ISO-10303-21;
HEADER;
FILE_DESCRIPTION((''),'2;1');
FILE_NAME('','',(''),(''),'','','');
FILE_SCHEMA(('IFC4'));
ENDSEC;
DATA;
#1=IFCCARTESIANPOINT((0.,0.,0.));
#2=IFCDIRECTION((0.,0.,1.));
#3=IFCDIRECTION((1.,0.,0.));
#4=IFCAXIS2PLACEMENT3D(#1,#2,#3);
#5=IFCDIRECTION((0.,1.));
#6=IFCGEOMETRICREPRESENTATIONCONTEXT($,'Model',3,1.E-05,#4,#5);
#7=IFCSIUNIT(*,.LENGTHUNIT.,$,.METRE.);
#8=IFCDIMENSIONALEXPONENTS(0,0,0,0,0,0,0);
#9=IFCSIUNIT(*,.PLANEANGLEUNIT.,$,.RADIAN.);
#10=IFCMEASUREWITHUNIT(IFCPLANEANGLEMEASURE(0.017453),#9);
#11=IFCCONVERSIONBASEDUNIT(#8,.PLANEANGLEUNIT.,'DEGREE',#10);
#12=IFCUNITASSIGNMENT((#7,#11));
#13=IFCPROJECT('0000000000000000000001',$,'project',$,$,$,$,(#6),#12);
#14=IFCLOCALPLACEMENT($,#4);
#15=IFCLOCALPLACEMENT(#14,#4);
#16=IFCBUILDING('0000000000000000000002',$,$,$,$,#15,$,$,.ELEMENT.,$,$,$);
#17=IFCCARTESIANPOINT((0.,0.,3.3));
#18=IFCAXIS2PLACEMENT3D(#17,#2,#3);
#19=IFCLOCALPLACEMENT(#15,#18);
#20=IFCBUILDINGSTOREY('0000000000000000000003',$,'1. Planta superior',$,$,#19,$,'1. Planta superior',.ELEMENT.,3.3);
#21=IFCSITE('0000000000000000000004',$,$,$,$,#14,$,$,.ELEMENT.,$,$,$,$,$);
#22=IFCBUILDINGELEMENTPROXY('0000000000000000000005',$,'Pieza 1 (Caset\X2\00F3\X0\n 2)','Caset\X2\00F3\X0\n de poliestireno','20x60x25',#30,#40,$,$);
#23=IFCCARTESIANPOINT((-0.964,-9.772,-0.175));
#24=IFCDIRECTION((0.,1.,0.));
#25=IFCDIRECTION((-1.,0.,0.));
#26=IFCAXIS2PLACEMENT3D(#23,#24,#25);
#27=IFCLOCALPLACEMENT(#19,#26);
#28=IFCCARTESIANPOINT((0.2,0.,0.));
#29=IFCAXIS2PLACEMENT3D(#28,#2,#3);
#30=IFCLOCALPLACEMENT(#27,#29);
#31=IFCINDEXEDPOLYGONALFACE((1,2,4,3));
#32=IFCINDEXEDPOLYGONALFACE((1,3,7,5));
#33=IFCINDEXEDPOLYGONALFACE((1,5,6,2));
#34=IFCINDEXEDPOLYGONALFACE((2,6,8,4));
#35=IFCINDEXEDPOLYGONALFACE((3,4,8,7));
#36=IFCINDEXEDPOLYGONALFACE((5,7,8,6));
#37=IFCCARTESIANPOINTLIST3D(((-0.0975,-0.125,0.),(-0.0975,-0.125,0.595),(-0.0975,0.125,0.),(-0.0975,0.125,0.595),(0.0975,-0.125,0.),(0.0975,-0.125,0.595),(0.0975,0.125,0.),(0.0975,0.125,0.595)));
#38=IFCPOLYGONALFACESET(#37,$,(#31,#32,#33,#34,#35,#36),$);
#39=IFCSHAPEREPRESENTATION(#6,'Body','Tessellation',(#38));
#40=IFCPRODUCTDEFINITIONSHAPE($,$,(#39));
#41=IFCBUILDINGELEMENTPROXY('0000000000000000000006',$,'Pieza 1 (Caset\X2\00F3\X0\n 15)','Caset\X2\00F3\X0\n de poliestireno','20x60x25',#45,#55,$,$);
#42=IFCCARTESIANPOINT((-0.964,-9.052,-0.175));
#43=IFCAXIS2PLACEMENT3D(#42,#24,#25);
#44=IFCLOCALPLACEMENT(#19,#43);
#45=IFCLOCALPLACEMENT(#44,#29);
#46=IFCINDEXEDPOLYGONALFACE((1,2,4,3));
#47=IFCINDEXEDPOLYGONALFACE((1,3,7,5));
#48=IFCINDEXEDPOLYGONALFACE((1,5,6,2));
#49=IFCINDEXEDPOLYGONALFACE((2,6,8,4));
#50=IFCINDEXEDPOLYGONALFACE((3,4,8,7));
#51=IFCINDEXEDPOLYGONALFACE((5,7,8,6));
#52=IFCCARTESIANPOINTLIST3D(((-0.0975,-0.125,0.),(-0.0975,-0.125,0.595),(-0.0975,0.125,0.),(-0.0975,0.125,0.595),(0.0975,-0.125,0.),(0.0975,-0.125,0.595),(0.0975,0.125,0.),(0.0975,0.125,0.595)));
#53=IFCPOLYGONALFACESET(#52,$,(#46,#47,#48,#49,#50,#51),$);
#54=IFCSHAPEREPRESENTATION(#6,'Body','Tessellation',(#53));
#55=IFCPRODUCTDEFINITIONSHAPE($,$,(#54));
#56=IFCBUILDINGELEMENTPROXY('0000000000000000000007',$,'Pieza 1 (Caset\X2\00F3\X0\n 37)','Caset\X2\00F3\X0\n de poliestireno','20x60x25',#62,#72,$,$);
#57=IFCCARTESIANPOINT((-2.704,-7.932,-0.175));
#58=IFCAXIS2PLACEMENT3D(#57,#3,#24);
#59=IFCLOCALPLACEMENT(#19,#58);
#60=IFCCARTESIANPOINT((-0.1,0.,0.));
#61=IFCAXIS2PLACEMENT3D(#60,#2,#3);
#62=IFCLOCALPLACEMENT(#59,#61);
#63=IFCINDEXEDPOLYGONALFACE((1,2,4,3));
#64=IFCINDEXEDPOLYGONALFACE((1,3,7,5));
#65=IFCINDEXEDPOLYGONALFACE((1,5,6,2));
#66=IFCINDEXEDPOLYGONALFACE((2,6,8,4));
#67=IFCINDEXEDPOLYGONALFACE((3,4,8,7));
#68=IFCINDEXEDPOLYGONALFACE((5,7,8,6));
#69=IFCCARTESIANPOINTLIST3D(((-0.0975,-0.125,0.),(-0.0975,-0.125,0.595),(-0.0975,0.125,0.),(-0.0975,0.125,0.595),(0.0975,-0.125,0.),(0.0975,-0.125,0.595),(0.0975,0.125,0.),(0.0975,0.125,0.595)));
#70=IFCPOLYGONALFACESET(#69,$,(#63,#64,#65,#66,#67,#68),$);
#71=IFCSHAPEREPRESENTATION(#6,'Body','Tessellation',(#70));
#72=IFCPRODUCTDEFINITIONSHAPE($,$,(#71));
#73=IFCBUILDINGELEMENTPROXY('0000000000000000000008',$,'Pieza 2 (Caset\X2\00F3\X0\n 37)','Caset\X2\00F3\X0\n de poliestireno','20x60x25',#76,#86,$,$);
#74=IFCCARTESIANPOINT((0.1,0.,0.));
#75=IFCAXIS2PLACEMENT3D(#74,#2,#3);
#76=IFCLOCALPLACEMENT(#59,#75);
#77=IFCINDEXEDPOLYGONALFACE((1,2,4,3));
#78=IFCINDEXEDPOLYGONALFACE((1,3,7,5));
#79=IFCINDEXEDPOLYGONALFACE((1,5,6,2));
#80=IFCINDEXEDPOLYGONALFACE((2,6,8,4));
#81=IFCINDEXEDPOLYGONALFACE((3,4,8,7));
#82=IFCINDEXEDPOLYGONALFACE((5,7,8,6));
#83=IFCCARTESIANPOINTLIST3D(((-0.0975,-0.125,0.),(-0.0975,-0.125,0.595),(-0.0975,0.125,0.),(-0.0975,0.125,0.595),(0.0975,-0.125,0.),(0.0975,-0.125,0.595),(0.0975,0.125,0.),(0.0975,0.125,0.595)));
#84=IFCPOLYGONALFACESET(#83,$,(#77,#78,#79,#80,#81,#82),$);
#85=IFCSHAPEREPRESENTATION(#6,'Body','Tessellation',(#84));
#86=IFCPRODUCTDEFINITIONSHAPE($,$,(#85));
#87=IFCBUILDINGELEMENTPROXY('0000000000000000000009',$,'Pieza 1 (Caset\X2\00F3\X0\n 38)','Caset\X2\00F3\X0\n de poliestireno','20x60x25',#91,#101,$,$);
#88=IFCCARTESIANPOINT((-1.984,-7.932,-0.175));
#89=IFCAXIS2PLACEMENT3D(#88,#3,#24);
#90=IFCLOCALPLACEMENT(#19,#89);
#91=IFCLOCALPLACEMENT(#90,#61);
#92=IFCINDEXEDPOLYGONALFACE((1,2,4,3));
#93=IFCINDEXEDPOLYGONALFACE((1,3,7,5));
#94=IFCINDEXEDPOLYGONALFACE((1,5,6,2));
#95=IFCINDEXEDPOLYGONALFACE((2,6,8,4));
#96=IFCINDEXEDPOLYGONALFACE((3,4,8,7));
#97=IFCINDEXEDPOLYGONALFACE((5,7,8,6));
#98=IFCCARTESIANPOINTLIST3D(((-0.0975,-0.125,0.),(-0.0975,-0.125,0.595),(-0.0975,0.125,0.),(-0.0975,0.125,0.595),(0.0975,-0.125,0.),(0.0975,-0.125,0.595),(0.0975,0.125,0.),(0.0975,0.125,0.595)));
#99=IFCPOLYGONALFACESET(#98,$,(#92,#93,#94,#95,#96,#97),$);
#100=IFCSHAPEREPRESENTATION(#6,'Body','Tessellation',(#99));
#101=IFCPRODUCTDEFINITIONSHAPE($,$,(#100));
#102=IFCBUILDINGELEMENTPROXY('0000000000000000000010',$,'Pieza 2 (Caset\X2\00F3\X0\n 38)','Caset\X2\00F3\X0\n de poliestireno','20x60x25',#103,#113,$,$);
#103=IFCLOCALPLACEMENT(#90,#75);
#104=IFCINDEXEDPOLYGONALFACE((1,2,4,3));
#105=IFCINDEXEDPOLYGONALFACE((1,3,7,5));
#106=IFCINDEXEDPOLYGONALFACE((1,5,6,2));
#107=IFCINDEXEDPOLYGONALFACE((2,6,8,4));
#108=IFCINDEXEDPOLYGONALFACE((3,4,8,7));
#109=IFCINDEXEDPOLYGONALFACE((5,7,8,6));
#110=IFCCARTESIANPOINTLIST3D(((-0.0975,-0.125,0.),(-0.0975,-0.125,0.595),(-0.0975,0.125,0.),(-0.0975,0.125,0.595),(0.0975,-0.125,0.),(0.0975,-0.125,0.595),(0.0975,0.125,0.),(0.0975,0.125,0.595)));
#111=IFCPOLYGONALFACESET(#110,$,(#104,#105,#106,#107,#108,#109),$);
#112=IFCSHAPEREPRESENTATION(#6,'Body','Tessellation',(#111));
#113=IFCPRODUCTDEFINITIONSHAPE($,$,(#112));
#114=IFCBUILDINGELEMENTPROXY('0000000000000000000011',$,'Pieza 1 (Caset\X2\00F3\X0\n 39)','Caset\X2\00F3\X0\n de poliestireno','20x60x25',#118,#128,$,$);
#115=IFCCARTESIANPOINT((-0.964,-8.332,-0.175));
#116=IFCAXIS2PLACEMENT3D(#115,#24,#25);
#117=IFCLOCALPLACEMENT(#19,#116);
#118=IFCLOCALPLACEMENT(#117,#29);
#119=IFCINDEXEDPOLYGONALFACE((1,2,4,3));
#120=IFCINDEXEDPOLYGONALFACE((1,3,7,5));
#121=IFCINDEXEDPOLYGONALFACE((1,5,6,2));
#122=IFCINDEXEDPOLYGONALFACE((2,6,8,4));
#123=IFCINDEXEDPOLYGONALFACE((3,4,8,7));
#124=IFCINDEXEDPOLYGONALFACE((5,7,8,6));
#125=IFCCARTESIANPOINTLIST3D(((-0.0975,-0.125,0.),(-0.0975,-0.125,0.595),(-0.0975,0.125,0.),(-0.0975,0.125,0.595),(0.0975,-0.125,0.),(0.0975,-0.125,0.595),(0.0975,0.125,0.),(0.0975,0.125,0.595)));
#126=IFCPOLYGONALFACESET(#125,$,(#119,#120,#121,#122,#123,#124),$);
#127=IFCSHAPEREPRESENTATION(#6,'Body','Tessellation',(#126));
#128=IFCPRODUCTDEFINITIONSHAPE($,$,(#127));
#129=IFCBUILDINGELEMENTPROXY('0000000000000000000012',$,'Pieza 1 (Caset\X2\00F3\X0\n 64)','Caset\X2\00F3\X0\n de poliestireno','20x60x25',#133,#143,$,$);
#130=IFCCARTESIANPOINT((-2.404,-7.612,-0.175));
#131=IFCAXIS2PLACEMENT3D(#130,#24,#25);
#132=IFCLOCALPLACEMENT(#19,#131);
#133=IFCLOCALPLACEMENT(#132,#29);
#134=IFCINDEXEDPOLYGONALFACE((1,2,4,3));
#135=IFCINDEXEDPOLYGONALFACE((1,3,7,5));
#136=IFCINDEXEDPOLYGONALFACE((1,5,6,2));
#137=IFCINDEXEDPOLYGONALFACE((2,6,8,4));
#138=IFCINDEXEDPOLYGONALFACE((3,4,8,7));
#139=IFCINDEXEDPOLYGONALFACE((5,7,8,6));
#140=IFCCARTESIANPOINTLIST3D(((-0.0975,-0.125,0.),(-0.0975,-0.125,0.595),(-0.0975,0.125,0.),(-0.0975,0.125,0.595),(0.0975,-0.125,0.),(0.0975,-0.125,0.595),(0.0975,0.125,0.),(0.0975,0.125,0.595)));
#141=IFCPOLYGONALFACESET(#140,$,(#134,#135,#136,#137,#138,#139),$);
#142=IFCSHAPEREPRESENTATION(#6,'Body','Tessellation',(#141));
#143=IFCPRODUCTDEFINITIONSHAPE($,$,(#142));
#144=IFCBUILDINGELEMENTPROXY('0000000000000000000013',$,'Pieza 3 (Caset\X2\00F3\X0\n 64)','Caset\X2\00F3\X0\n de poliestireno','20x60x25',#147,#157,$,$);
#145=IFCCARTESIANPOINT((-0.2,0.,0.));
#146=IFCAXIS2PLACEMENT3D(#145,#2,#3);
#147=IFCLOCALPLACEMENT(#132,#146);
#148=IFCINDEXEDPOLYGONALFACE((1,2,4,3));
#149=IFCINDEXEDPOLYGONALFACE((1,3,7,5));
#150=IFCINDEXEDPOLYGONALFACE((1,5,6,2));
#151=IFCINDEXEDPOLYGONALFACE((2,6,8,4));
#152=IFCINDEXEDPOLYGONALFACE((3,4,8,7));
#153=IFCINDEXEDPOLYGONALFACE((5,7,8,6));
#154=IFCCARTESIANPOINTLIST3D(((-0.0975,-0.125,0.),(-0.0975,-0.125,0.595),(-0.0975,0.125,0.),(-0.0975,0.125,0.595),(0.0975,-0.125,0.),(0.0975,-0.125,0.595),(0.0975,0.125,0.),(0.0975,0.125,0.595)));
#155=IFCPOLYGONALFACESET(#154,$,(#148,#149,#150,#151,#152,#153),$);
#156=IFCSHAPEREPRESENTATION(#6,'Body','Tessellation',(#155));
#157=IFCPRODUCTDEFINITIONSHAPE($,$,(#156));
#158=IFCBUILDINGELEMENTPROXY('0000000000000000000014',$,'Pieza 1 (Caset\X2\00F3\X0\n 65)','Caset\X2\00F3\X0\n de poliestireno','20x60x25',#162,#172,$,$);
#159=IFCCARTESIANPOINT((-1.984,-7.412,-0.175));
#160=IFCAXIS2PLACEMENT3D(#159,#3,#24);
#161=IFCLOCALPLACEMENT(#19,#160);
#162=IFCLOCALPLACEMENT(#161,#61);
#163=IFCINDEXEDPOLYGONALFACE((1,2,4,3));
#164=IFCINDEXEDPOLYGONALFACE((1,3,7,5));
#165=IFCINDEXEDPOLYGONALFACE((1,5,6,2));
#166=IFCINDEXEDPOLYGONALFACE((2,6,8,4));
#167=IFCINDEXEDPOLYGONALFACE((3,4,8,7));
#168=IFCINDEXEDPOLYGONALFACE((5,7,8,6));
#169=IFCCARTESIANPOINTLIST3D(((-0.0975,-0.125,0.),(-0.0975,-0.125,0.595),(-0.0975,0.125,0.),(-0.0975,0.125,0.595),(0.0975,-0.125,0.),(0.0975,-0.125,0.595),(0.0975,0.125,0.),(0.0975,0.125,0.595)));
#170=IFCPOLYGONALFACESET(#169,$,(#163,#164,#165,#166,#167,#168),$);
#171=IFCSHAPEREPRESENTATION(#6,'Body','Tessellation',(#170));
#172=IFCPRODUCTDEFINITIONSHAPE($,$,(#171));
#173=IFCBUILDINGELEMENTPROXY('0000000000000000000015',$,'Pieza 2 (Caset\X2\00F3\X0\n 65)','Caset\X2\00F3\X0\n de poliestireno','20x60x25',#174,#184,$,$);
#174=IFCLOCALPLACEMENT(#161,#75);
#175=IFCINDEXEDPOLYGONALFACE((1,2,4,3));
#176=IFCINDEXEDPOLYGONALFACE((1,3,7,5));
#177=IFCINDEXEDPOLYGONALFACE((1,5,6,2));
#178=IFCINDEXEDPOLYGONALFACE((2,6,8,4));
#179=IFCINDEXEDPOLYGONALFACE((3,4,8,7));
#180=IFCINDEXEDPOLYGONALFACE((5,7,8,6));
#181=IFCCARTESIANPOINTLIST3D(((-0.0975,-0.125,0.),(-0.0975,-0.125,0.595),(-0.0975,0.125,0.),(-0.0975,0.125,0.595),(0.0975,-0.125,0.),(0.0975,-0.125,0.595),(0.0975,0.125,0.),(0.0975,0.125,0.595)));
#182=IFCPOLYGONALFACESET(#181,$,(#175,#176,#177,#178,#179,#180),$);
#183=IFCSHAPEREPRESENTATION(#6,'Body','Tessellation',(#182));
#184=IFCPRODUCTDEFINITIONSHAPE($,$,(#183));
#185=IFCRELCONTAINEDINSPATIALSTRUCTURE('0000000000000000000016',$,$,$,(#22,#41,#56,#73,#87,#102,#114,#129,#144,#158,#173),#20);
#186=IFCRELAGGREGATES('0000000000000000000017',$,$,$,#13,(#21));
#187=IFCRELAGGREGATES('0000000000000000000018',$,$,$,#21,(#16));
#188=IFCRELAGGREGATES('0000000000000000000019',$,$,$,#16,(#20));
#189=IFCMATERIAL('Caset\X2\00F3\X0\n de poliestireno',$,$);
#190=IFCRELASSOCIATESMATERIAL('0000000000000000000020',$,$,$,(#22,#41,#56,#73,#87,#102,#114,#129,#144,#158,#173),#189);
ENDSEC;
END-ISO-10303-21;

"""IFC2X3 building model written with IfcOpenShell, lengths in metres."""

from ifc_helpers import new_model, entity, si_unit, converted_unit, direction, frame, origin_with_axes, origin_2d_with_axis, place, context, project, spatial, rectangle, extrude, source, transform, mapped, material, element, save


model = new_model("IFC2X3")

# Units and contexts
model_context = context("Model", 3, precision=1e-05, world=origin_with_axes(), true_north=direction((0.0, 1.0)))
ifc_project = project(units=[si_unit("LENGTHUNIT", "METRE"), converted_unit("PLANEANGLEUNIT", "DEGREE", entity("IfcPlaneAngleMeasure", 0.017453), si_unit("PLANEANGLEUNIT", "RADIAN"), dimensions=[0, 0, 0, 0, 0, 0, 0])], contexts=[model_context])

# Site, building, storey
site_placement = place(None, origin_with_axes())
site = spatial("IfcSite", under=ifc_project, at=site_placement, CompositionType="ELEMENT")
building_placement = place(site_placement, origin_with_axes())
building = spatial("IfcBuilding", under=site, at=building_placement, CompositionType="ELEMENT")
storey_placement = place(building_placement, frame((0.0, 0.0, 3.3), z_axis=(0.0, 0.0, 1.0), x_axis=(1.0, 0.0, 0.0)))
storey = spatial("IfcBuildingStorey", under=building, at=storey_placement, Name="1. Planta superior", LongName="1. Planta superior", CompositionType="ELEMENT", Elevation=3.3)

# Building element proxies
ifc_material_1 = material(Name="Casetón de poliestireno")
shared_shape = source(origin_with_axes(), model_context, "Body", "SweptSolid", [
    extrude(rectangle(XDim=0.195, YDim=0.25, at=origin_2d_with_axis()), origin_with_axes(), (0.0, 0.0, 1.0), 0.595),
])
placement_1 = place(storey_placement, frame((-0.964, -9.772, -0.175), z_axis=(0.0, 1.0, 0.0), x_axis=(-1.0, 0.0, 0.0)))
for number, where, z_axis, x_axis, name in (
    (1, (0.2, 0.0, 0.0), (0.0, 0.0, 1.0), (1.0, 0.0, 0.0), "Pieza 1 (Casetón 2)"),
):
    element("IfcBuildingElementProxy", number, at=place(placement_1, frame(where, z_axis=z_axis, x_axis=x_axis)), inside=storey, material=ifc_material_1, Name=name, Description="Casetón de poliestireno", ObjectType="20x60x25", context=model_context, shape_type="MappedRepresentation", body=[
        mapped(shared_shape, transform((0.0, 0.0, 0.0), x_axis=(1.0, 0.0, 0.0), y_axis=(0.0, 1.0, 0.0), z_axis=(0.0, 0.0, 1.0))),
    ])
placement_2 = place(storey_placement, frame((-0.964, -9.052, -0.175), z_axis=(0.0, 1.0, 0.0), x_axis=(-1.0, 0.0, 0.0)))
for number, where, z_axis, x_axis, name in (
    (2, (0.2, 0.0, 0.0), (0.0, 0.0, 1.0), (1.0, 0.0, 0.0), "Pieza 1 (Casetón 15)"),
):
    element("IfcBuildingElementProxy", number, at=place(placement_2, frame(where, z_axis=z_axis, x_axis=x_axis)), inside=storey, material=ifc_material_1, Name=name, Description="Casetón de poliestireno", ObjectType="20x60x25", context=model_context, shape_type="MappedRepresentation", body=[
        mapped(shared_shape, transform((0.0, 0.0, 0.0), x_axis=(1.0, 0.0, 0.0), y_axis=(0.0, 1.0, 0.0), z_axis=(0.0, 0.0, 1.0))),
    ])
placement_3 = place(storey_placement, frame((-2.704, -7.932, -0.175), z_axis=(1.0, 0.0, 0.0), x_axis=(0.0, 1.0, 0.0)))
for number, where, z_axis, x_axis, name in (
    (3, (-0.1, 0.0, 0.0), (0.0, 0.0, 1.0), (1.0, 0.0, 0.0), "Pieza 1 (Casetón 37)"),
    (4, (0.1, 0.0, 0.0), (0.0, 0.0, 1.0), (1.0, 0.0, 0.0), "Pieza 2 (Casetón 37)"),
):
    element("IfcBuildingElementProxy", number, at=place(placement_3, frame(where, z_axis=z_axis, x_axis=x_axis)), inside=storey, material=ifc_material_1, Name=name, Description="Casetón de poliestireno", ObjectType="20x60x25", context=model_context, shape_type="MappedRepresentation", body=[
        mapped(shared_shape, transform((0.0, 0.0, 0.0), x_axis=(1.0, 0.0, 0.0), y_axis=(0.0, 1.0, 0.0), z_axis=(0.0, 0.0, 1.0))),
    ])
placement_4 = place(storey_placement, frame((-1.984, -7.932, -0.175), z_axis=(1.0, 0.0, 0.0), x_axis=(0.0, 1.0, 0.0)))
for number, where, z_axis, x_axis, name in (
    (5, (-0.1, 0.0, 0.0), (0.0, 0.0, 1.0), (1.0, 0.0, 0.0), "Pieza 1 (Casetón 38)"),
    (6, (0.1, 0.0, 0.0), (0.0, 0.0, 1.0), (1.0, 0.0, 0.0), "Pieza 2 (Casetón 38)"),
):
    element("IfcBuildingElementProxy", number, at=place(placement_4, frame(where, z_axis=z_axis, x_axis=x_axis)), inside=storey, material=ifc_material_1, Name=name, Description="Casetón de poliestireno", ObjectType="20x60x25", context=model_context, shape_type="MappedRepresentation", body=[
        mapped(shared_shape, transform((0.0, 0.0, 0.0), x_axis=(1.0, 0.0, 0.0), y_axis=(0.0, 1.0, 0.0), z_axis=(0.0, 0.0, 1.0))),
    ])
placement_5 = place(storey_placement, frame((-0.964, -8.332, -0.175), z_axis=(0.0, 1.0, 0.0), x_axis=(-1.0, 0.0, 0.0)))
for number, where, z_axis, x_axis, name in (
    (7, (0.2, 0.0, 0.0), (0.0, 0.0, 1.0), (1.0, 0.0, 0.0), "Pieza 1 (Casetón 39)"),
):
    element("IfcBuildingElementProxy", number, at=place(placement_5, frame(where, z_axis=z_axis, x_axis=x_axis)), inside=storey, material=ifc_material_1, Name=name, Description="Casetón de poliestireno", ObjectType="20x60x25", context=model_context, shape_type="MappedRepresentation", body=[
        mapped(shared_shape, transform((0.0, 0.0, 0.0), x_axis=(1.0, 0.0, 0.0), y_axis=(0.0, 1.0, 0.0), z_axis=(0.0, 0.0, 1.0))),
    ])
placement_6 = place(storey_placement, frame((-2.404, -7.612, -0.175), z_axis=(0.0, 1.0, 0.0), x_axis=(-1.0, 0.0, 0.0)))
for number, where, z_axis, x_axis, name in (
    (8, (0.2, 0.0, 0.0), (0.0, 0.0, 1.0), (1.0, 0.0, 0.0), "Pieza 1 (Casetón 64)"),
    (9, (-0.2, 0.0, 0.0), (0.0, 0.0, 1.0), (1.0, 0.0, 0.0), "Pieza 3 (Casetón 64)"),
):
    element("IfcBuildingElementProxy", number, at=place(placement_6, frame(where, z_axis=z_axis, x_axis=x_axis)), inside=storey, material=ifc_material_1, Name=name, Description="Casetón de poliestireno", ObjectType="20x60x25", context=model_context, shape_type="MappedRepresentation", body=[
        mapped(shared_shape, transform((0.0, 0.0, 0.0), x_axis=(1.0, 0.0, 0.0), y_axis=(0.0, 1.0, 0.0), z_axis=(0.0, 0.0, 1.0))),
    ])
placement_7 = place(storey_placement, frame((-1.984, -7.412, -0.175), z_axis=(1.0, 0.0, 0.0), x_axis=(0.0, 1.0, 0.0)))
for number, where, z_axis, x_axis, name in (
    (10, (-0.1, 0.0, 0.0), (0.0, 0.0, 1.0), (1.0, 0.0, 0.0), "Pieza 1 (Casetón 65)"),
    (11, (0.1, 0.0, 0.0), (0.0, 0.0, 1.0), (1.0, 0.0, 0.0), "Pieza 2 (Casetón 65)"),
):
    element("IfcBuildingElementProxy", number, at=place(placement_7, frame(where, z_axis=z_axis, x_axis=x_axis)), inside=storey, material=ifc_material_1, Name=name, Description="Casetón de poliestireno", ObjectType="20x60x25", context=model_context, shape_type="MappedRepresentation", body=[
        mapped(shared_shape, transform((0.0, 0.0, 0.0), x_axis=(1.0, 0.0, 0.0), y_axis=(0.0, 1.0, 0.0), z_axis=(0.0, 0.0, 1.0))),
    ])

save(model, "model.ifc")
